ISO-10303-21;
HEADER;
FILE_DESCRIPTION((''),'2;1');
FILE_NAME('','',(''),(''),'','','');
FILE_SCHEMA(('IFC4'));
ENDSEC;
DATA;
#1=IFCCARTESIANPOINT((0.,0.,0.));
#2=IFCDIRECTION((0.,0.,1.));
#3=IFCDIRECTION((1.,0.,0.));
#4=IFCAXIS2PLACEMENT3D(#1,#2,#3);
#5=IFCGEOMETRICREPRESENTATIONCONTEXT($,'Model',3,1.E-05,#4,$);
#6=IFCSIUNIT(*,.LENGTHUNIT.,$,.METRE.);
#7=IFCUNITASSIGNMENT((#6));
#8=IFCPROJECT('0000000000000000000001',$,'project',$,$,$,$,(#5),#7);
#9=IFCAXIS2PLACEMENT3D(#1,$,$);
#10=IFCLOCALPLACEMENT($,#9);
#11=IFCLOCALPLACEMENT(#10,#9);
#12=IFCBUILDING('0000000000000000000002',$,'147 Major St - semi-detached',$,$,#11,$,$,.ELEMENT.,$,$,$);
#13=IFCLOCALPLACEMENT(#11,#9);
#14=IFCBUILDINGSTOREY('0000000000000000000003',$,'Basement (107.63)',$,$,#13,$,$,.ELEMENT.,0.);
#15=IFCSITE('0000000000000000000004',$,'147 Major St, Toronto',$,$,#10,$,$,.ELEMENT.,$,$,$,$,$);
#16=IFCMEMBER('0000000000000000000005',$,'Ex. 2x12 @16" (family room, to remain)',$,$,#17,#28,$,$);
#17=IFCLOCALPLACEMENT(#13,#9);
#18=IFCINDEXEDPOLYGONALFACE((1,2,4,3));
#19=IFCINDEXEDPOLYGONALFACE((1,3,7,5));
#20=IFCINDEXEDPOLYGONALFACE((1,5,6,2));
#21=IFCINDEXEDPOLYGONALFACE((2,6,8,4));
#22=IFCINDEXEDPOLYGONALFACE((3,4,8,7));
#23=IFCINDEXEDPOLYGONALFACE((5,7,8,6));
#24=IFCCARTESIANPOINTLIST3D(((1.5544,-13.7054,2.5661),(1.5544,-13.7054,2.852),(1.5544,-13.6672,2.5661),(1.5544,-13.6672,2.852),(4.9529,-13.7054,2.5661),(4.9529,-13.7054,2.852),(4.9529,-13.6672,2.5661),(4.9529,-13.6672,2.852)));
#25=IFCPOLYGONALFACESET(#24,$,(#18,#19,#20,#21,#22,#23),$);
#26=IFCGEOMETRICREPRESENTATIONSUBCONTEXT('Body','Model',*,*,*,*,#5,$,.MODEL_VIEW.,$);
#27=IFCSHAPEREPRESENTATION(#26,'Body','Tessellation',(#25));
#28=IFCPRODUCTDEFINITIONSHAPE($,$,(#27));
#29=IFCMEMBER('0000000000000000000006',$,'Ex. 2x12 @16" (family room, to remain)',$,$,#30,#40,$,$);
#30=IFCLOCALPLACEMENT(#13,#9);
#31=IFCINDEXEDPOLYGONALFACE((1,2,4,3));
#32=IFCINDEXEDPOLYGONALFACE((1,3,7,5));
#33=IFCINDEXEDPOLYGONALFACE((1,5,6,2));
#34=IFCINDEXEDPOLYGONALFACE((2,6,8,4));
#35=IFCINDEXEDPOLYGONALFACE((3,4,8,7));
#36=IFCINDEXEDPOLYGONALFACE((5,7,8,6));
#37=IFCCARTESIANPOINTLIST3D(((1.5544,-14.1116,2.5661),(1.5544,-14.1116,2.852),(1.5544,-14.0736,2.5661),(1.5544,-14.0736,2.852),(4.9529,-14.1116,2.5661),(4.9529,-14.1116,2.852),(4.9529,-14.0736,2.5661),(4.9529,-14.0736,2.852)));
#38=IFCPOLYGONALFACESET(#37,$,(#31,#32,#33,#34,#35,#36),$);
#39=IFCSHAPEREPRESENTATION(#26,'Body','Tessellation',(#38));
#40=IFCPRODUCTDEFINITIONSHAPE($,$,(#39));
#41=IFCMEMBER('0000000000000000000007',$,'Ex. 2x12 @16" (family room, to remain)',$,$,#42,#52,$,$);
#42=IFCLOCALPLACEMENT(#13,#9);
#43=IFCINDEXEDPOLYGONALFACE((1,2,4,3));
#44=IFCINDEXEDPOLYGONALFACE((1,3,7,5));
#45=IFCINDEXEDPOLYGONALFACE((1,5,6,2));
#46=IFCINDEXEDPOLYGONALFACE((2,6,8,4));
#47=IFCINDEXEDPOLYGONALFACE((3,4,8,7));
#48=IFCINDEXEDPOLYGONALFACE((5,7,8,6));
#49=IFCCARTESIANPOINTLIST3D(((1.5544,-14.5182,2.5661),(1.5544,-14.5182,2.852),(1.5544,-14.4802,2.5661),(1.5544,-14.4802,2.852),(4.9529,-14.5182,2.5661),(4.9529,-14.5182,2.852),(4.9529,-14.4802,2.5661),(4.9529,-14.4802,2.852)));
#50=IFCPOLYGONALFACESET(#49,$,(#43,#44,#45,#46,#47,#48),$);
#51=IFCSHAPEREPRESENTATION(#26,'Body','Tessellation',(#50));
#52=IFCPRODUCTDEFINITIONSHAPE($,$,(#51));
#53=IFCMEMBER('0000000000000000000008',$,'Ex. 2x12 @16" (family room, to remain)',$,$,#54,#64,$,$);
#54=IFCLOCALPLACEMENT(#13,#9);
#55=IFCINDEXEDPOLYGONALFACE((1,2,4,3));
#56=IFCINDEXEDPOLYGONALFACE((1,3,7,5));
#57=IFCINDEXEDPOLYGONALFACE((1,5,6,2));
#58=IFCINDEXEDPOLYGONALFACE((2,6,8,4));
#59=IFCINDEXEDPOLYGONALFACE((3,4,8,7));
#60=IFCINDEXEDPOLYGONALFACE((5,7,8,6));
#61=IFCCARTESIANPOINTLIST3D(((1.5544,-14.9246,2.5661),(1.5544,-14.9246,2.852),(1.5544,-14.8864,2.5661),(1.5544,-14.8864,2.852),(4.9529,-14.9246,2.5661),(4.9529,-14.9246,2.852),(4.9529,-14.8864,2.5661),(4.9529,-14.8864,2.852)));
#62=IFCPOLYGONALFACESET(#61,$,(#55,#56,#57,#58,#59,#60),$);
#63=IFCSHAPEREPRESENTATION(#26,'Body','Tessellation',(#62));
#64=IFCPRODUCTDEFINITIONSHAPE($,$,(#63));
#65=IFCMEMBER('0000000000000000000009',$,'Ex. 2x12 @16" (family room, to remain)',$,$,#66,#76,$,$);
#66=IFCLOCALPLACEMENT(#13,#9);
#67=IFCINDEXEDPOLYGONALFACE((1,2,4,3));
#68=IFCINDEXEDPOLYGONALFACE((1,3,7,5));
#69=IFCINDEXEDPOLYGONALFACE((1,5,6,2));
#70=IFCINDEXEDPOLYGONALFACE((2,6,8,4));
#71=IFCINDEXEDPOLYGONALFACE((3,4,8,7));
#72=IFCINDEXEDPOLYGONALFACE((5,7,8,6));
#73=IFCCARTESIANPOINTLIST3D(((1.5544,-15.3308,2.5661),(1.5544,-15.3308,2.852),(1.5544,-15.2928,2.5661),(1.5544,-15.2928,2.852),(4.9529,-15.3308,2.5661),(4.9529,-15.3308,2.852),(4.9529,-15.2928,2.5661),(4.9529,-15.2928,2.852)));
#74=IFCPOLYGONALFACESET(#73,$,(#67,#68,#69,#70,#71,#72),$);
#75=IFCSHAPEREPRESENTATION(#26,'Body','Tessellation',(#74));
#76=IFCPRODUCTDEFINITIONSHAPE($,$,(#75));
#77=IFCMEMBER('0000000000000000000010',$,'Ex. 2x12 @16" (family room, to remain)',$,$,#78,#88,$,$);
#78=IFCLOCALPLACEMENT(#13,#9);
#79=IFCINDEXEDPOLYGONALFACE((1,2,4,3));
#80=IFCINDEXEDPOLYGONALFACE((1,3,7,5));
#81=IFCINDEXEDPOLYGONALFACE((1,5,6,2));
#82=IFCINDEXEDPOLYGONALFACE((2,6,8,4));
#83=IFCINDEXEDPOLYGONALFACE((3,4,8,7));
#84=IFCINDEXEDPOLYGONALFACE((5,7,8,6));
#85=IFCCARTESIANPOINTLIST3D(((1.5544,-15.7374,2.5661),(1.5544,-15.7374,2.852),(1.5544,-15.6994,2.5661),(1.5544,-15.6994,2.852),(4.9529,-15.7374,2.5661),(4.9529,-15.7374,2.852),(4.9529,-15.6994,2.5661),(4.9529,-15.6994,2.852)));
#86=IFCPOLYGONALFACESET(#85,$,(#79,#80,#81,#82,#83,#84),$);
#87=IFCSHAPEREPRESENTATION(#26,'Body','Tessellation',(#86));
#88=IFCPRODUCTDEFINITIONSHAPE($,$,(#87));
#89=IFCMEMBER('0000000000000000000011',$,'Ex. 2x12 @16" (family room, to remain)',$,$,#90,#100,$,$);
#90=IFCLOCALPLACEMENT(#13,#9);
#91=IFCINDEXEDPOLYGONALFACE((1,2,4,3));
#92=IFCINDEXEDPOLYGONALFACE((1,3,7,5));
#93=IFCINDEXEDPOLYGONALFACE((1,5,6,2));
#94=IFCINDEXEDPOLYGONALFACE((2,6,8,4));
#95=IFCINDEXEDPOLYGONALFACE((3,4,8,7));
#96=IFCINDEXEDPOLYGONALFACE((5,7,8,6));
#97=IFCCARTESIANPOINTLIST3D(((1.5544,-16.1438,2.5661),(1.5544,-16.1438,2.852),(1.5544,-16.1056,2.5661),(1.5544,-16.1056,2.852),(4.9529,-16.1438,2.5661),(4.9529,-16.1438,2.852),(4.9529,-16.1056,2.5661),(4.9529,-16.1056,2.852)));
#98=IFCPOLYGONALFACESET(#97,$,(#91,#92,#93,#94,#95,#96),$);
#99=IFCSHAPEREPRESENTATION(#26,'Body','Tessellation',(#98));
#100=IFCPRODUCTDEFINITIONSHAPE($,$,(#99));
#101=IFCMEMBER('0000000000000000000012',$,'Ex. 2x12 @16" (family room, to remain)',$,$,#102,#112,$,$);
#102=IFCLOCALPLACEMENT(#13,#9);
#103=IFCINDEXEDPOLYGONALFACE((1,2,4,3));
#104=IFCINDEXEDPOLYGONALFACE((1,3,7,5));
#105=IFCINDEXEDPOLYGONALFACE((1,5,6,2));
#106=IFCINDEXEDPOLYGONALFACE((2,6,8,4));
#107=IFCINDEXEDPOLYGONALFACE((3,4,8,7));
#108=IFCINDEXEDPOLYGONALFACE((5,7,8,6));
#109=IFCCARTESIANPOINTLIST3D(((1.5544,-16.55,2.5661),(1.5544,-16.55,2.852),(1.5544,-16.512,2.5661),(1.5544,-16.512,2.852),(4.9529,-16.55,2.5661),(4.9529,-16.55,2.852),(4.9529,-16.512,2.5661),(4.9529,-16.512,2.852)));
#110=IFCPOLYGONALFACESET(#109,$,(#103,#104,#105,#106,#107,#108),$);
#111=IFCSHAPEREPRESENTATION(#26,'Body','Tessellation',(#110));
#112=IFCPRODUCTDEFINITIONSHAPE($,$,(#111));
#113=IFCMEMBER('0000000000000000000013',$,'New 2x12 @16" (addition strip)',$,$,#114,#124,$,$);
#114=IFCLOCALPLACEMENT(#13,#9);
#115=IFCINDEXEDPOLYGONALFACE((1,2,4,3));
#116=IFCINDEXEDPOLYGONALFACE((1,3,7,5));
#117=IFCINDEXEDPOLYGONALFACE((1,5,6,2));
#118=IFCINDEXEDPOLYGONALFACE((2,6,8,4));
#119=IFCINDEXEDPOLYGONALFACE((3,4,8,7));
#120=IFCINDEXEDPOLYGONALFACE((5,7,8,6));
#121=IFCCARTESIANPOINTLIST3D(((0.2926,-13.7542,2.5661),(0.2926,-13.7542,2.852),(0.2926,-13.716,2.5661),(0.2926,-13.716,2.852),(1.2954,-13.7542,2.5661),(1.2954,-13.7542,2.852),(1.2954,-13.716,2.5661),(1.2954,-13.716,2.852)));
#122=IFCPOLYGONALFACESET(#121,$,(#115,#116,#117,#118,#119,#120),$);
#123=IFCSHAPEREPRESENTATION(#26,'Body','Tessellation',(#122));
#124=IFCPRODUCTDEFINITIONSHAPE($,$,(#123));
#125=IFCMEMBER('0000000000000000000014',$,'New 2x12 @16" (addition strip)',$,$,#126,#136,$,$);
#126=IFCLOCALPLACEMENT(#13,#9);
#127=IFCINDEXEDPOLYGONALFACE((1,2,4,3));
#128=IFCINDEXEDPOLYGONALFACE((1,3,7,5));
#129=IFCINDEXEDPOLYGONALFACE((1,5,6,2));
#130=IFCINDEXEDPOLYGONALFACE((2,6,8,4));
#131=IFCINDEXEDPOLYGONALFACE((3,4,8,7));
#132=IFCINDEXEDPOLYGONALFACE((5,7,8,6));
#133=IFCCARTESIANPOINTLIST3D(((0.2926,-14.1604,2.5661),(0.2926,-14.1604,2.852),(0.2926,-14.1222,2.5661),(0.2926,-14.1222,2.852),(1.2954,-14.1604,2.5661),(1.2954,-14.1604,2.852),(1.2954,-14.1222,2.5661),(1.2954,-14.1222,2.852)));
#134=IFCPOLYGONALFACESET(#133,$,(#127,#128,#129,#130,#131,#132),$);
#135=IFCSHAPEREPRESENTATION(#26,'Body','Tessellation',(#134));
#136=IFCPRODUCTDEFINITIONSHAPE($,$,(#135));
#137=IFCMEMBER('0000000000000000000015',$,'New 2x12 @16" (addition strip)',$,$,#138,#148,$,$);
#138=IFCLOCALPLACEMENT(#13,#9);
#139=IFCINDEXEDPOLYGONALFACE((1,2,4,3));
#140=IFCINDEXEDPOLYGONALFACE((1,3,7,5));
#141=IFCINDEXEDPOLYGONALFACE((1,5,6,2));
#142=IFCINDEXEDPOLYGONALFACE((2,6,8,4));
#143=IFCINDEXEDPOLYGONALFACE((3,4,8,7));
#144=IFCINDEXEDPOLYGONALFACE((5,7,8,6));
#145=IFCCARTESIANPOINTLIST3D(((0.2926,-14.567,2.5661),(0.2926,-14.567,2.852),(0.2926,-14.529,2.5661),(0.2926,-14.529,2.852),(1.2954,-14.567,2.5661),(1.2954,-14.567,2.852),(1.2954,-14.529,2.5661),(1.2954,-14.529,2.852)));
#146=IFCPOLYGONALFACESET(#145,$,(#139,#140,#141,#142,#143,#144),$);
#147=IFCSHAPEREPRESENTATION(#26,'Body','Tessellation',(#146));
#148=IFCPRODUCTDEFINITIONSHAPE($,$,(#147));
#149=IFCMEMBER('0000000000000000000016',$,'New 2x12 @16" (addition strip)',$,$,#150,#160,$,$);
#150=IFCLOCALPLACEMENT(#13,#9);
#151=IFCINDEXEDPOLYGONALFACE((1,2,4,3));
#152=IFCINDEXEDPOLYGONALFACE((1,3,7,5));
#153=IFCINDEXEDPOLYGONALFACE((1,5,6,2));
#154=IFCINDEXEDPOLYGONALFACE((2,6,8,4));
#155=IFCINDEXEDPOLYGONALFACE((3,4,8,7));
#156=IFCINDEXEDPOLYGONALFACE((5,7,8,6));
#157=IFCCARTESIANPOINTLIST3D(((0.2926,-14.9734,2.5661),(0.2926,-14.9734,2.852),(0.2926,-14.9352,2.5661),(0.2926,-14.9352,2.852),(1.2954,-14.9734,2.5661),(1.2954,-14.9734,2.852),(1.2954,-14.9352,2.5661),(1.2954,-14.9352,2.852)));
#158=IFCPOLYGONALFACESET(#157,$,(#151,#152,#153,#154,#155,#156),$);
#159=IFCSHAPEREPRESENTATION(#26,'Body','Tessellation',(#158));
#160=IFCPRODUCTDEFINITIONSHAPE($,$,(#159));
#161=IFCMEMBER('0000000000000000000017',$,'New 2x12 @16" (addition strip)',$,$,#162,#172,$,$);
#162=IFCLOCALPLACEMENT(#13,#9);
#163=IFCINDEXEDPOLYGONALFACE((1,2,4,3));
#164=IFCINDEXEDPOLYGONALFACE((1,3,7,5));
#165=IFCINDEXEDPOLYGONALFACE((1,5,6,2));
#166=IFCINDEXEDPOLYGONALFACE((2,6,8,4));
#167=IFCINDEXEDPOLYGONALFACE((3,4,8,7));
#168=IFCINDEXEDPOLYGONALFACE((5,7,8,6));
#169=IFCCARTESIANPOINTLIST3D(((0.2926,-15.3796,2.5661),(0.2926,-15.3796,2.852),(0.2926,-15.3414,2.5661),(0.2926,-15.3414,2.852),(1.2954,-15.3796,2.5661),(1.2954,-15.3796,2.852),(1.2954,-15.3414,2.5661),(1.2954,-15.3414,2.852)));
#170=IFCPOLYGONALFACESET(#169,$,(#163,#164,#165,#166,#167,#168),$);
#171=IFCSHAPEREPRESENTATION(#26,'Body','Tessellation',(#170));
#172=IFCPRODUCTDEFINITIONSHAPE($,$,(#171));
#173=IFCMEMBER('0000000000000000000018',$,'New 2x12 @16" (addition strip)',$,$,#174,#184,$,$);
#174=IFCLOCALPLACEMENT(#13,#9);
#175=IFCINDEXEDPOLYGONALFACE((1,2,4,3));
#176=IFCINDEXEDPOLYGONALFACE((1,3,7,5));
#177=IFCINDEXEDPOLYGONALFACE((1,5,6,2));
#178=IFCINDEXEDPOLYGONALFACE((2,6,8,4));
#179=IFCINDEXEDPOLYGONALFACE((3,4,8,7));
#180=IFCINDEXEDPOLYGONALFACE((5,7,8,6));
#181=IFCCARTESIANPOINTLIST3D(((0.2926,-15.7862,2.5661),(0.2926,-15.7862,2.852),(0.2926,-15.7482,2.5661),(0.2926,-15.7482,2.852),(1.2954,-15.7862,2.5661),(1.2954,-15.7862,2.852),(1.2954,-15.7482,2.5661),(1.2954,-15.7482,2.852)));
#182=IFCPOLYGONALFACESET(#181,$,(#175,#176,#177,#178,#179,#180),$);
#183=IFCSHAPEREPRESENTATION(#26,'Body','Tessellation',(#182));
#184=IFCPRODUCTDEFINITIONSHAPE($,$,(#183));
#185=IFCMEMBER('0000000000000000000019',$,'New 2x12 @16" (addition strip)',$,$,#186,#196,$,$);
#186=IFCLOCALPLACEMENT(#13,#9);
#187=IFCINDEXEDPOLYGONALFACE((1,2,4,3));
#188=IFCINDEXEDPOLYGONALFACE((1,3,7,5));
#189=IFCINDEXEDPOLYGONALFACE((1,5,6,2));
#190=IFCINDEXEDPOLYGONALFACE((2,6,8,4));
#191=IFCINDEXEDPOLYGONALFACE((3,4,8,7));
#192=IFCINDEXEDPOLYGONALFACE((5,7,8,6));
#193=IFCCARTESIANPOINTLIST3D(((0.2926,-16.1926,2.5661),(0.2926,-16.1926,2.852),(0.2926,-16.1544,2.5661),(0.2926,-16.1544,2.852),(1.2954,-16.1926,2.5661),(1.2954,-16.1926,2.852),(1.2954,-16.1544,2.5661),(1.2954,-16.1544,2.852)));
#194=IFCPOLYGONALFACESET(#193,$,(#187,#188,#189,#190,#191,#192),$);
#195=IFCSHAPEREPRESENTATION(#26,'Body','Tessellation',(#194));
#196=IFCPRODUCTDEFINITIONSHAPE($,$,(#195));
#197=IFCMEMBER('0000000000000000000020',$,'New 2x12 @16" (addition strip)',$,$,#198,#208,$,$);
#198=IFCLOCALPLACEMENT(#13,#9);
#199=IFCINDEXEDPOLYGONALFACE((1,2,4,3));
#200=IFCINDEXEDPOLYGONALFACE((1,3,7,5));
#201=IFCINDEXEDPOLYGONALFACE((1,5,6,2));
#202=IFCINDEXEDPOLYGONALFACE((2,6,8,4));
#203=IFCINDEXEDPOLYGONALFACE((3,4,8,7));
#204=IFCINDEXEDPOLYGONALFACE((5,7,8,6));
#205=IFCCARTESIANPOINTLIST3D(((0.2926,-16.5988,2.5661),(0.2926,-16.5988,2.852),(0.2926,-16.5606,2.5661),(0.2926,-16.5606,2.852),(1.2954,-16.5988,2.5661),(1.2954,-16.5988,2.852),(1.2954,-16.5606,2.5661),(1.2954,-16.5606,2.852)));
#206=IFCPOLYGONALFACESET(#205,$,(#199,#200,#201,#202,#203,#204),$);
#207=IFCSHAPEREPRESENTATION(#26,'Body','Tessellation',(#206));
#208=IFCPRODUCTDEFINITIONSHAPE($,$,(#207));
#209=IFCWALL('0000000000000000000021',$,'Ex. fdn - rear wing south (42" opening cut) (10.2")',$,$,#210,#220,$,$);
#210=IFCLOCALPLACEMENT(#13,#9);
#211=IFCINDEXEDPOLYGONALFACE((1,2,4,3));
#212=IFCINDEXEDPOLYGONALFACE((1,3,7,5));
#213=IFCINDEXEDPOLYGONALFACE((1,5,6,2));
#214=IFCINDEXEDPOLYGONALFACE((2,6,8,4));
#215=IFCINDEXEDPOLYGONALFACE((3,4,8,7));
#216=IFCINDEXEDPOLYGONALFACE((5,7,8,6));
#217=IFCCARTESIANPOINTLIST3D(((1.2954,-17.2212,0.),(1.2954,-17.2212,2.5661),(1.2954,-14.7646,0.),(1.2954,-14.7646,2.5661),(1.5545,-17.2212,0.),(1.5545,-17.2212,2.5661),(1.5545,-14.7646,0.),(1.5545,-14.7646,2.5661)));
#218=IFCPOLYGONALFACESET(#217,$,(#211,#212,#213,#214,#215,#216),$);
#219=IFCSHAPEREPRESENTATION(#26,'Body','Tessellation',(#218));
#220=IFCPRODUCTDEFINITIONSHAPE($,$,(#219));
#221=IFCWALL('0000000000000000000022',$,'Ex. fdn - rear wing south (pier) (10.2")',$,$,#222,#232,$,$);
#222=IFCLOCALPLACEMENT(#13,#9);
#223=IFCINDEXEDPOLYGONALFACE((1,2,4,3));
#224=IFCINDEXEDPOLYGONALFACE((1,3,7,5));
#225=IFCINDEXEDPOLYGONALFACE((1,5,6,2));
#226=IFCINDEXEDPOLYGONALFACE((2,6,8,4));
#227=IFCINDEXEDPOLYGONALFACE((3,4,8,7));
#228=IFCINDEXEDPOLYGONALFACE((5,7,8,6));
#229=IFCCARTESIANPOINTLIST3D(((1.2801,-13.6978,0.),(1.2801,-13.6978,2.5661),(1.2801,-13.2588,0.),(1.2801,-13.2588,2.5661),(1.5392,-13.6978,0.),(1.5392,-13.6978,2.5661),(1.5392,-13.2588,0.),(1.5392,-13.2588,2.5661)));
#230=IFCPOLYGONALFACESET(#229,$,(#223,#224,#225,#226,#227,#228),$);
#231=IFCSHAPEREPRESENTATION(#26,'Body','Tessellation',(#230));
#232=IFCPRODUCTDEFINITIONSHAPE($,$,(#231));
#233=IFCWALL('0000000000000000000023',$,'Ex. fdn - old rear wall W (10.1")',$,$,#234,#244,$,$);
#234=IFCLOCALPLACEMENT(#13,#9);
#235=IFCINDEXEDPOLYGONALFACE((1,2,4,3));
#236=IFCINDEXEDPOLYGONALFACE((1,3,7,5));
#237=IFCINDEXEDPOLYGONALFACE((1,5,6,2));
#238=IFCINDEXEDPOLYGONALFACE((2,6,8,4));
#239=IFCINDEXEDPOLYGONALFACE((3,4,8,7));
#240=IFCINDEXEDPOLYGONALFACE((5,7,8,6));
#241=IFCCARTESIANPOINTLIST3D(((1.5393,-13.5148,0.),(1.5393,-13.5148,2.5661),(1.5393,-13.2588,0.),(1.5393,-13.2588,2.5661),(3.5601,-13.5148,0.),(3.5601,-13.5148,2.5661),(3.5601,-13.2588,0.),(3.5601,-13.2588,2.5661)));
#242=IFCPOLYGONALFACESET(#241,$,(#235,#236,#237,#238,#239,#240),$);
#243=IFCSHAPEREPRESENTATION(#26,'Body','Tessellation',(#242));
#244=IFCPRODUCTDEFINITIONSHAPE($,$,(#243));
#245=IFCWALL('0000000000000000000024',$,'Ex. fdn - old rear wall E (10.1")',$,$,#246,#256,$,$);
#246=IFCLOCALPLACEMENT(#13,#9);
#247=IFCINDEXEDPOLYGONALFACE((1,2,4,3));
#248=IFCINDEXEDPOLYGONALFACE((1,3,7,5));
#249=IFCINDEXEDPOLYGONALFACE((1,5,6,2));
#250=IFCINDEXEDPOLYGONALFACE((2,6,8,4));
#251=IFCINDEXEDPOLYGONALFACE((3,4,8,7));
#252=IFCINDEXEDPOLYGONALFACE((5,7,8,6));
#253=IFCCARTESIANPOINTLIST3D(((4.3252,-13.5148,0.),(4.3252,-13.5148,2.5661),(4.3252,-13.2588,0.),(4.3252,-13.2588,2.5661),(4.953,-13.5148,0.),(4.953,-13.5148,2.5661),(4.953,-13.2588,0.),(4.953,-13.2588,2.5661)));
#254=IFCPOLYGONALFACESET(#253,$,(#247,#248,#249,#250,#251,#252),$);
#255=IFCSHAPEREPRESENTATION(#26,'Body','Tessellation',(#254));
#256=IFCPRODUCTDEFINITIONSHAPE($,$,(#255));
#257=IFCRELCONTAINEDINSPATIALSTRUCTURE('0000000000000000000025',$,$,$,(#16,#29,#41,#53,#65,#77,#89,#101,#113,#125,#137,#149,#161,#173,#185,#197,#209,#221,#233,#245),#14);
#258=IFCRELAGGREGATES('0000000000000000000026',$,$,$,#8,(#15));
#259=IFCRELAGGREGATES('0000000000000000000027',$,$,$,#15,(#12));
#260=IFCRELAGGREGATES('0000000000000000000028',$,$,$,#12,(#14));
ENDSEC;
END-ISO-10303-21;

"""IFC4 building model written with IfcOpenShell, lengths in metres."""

from ifc_helpers import new_model, si_unit, frame, origin, origin_with_axes, place, context, subcontext, project, spatial, rectangle, extrude, element, save


model = new_model("IFC4")

# Units and contexts
model_context = context("Model", 3, precision=1e-05, world=origin_with_axes())
body_context = subcontext(model_context, "Body", "Model", "MODEL_VIEW")
ifc_project = project(units=[si_unit("LENGTHUNIT", "METRE")], contexts=[model_context])

# Site, building, storey
site_placement = place(None, origin())
site = spatial("IfcSite", under=ifc_project, at=site_placement, Name="147 Major St, Toronto", CompositionType="ELEMENT")
building_placement = place(site_placement, origin())
building = spatial("IfcBuilding", under=site, at=building_placement, Name="147 Major St - semi-detached", CompositionType="ELEMENT")
storey_placement = place(building_placement, origin())
storey = spatial("IfcBuildingStorey", under=building, at=storey_placement, Name="Basement (107.63)", CompositionType="ELEMENT", Elevation=0.0)

# Members
for number, where, name in (
    (1, (3.2537, -13.6863, 2.5661), "Ex. 2x12 @16\" (family room, to remain)"),
    (2, (3.2537, -14.0926, 2.5661), "Ex. 2x12 @16\" (family room, to remain)"),
    (3, (3.2537, -14.4992, 2.5661), "Ex. 2x12 @16\" (family room, to remain)"),
    (4, (3.2537, -14.9055, 2.5661), "Ex. 2x12 @16\" (family room, to remain)"),
    (5, (3.2537, -15.3118, 2.5661), "Ex. 2x12 @16\" (family room, to remain)"),
    (6, (3.2537, -15.7184, 2.5661), "Ex. 2x12 @16\" (family room, to remain)"),
    (7, (3.2537, -16.1247, 2.5661), "Ex. 2x12 @16\" (family room, to remain)"),
    (8, (3.2537, -16.531, 2.5661), "Ex. 2x12 @16\" (family room, to remain)"),
):
    element("IfcMember", number, at=place(storey_placement, frame(where)), inside=storey, Name=name, context=body_context, shape_type="SweptSolid", body=[
        extrude(rectangle(XDim=3.3985, YDim=0.0381), origin_with_axes(), (0.0, 0.0, 1.0), 0.2859),
    ])
for number, where, name in (
    (9, (0.794, -13.7351, 2.5661), "New 2x12 @16\" (addition strip)"),
    (10, (0.794, -14.1413, 2.5661), "New 2x12 @16\" (addition strip)"),
    (11, (0.794, -14.548, 2.5661), "New 2x12 @16\" (addition strip)"),
    (12, (0.794, -14.9543, 2.5661), "New 2x12 @16\" (addition strip)"),
    (13, (0.794, -15.3605, 2.5661), "New 2x12 @16\" (addition strip)"),
    (14, (0.794, -15.7672, 2.5661), "New 2x12 @16\" (addition strip)"),
    (15, (0.794, -16.1735, 2.5661), "New 2x12 @16\" (addition strip)"),
    (16, (0.794, -16.5797, 2.5661), "New 2x12 @16\" (addition strip)"),
):
    element("IfcMember", number, at=place(storey_placement, frame(where)), inside=storey, Name=name, context=body_context, shape_type="SweptSolid", body=[
        extrude(rectangle(XDim=1.0028, YDim=0.0381), origin_with_axes(), (0.0, 0.0, 1.0), 0.2859),
    ])

# Walls
wall_1_placement = place(storey_placement, frame((1.4249, -15.9929, 0.0)))
element("IfcWall", 17, at=wall_1_placement, inside=storey, Name="Ex. fdn - rear wing south (42\" opening cut) (10.2\")", context=body_context, shape_type="SweptSolid", body=[
    extrude(rectangle(XDim=0.2591, YDim=2.4567), origin_with_axes(), (0.0, 0.0, 1.0), 2.5661),
])
wall_2_placement = place(storey_placement, frame((1.4097, -13.4783, 0.0)))
element("IfcWall", 18, at=wall_2_placement, inside=storey, Name="Ex. fdn - rear wing south (pier) (10.2\")", context=body_context, shape_type="SweptSolid", body=[
    extrude(rectangle(XDim=0.2591, YDim=0.4389), origin_with_axes(), (0.0, 0.0, 1.0), 2.5661),
])
wall_3_placement = place(storey_placement, frame((2.5497, -13.3868, 0.0)))
element("IfcWall", 19, at=wall_3_placement, inside=storey, Name="Ex. fdn - old rear wall W (10.1\")", context=body_context, shape_type="SweptSolid", body=[
    extrude(rectangle(XDim=2.0208, YDim=0.256), origin_with_axes(), (0.0, 0.0, 1.0), 2.5661),
])
wall_4_placement = place(storey_placement, frame((4.6391, -13.3868, 0.0)))
element("IfcWall", 20, at=wall_4_placement, inside=storey, Name="Ex. fdn - old rear wall E (10.1\")", context=body_context, shape_type="SweptSolid", body=[
    extrude(rectangle(XDim=0.6279, YDim=0.256), origin_with_axes(), (0.0, 0.0, 1.0), 2.5661),
])

save(model, "model.ifc")
